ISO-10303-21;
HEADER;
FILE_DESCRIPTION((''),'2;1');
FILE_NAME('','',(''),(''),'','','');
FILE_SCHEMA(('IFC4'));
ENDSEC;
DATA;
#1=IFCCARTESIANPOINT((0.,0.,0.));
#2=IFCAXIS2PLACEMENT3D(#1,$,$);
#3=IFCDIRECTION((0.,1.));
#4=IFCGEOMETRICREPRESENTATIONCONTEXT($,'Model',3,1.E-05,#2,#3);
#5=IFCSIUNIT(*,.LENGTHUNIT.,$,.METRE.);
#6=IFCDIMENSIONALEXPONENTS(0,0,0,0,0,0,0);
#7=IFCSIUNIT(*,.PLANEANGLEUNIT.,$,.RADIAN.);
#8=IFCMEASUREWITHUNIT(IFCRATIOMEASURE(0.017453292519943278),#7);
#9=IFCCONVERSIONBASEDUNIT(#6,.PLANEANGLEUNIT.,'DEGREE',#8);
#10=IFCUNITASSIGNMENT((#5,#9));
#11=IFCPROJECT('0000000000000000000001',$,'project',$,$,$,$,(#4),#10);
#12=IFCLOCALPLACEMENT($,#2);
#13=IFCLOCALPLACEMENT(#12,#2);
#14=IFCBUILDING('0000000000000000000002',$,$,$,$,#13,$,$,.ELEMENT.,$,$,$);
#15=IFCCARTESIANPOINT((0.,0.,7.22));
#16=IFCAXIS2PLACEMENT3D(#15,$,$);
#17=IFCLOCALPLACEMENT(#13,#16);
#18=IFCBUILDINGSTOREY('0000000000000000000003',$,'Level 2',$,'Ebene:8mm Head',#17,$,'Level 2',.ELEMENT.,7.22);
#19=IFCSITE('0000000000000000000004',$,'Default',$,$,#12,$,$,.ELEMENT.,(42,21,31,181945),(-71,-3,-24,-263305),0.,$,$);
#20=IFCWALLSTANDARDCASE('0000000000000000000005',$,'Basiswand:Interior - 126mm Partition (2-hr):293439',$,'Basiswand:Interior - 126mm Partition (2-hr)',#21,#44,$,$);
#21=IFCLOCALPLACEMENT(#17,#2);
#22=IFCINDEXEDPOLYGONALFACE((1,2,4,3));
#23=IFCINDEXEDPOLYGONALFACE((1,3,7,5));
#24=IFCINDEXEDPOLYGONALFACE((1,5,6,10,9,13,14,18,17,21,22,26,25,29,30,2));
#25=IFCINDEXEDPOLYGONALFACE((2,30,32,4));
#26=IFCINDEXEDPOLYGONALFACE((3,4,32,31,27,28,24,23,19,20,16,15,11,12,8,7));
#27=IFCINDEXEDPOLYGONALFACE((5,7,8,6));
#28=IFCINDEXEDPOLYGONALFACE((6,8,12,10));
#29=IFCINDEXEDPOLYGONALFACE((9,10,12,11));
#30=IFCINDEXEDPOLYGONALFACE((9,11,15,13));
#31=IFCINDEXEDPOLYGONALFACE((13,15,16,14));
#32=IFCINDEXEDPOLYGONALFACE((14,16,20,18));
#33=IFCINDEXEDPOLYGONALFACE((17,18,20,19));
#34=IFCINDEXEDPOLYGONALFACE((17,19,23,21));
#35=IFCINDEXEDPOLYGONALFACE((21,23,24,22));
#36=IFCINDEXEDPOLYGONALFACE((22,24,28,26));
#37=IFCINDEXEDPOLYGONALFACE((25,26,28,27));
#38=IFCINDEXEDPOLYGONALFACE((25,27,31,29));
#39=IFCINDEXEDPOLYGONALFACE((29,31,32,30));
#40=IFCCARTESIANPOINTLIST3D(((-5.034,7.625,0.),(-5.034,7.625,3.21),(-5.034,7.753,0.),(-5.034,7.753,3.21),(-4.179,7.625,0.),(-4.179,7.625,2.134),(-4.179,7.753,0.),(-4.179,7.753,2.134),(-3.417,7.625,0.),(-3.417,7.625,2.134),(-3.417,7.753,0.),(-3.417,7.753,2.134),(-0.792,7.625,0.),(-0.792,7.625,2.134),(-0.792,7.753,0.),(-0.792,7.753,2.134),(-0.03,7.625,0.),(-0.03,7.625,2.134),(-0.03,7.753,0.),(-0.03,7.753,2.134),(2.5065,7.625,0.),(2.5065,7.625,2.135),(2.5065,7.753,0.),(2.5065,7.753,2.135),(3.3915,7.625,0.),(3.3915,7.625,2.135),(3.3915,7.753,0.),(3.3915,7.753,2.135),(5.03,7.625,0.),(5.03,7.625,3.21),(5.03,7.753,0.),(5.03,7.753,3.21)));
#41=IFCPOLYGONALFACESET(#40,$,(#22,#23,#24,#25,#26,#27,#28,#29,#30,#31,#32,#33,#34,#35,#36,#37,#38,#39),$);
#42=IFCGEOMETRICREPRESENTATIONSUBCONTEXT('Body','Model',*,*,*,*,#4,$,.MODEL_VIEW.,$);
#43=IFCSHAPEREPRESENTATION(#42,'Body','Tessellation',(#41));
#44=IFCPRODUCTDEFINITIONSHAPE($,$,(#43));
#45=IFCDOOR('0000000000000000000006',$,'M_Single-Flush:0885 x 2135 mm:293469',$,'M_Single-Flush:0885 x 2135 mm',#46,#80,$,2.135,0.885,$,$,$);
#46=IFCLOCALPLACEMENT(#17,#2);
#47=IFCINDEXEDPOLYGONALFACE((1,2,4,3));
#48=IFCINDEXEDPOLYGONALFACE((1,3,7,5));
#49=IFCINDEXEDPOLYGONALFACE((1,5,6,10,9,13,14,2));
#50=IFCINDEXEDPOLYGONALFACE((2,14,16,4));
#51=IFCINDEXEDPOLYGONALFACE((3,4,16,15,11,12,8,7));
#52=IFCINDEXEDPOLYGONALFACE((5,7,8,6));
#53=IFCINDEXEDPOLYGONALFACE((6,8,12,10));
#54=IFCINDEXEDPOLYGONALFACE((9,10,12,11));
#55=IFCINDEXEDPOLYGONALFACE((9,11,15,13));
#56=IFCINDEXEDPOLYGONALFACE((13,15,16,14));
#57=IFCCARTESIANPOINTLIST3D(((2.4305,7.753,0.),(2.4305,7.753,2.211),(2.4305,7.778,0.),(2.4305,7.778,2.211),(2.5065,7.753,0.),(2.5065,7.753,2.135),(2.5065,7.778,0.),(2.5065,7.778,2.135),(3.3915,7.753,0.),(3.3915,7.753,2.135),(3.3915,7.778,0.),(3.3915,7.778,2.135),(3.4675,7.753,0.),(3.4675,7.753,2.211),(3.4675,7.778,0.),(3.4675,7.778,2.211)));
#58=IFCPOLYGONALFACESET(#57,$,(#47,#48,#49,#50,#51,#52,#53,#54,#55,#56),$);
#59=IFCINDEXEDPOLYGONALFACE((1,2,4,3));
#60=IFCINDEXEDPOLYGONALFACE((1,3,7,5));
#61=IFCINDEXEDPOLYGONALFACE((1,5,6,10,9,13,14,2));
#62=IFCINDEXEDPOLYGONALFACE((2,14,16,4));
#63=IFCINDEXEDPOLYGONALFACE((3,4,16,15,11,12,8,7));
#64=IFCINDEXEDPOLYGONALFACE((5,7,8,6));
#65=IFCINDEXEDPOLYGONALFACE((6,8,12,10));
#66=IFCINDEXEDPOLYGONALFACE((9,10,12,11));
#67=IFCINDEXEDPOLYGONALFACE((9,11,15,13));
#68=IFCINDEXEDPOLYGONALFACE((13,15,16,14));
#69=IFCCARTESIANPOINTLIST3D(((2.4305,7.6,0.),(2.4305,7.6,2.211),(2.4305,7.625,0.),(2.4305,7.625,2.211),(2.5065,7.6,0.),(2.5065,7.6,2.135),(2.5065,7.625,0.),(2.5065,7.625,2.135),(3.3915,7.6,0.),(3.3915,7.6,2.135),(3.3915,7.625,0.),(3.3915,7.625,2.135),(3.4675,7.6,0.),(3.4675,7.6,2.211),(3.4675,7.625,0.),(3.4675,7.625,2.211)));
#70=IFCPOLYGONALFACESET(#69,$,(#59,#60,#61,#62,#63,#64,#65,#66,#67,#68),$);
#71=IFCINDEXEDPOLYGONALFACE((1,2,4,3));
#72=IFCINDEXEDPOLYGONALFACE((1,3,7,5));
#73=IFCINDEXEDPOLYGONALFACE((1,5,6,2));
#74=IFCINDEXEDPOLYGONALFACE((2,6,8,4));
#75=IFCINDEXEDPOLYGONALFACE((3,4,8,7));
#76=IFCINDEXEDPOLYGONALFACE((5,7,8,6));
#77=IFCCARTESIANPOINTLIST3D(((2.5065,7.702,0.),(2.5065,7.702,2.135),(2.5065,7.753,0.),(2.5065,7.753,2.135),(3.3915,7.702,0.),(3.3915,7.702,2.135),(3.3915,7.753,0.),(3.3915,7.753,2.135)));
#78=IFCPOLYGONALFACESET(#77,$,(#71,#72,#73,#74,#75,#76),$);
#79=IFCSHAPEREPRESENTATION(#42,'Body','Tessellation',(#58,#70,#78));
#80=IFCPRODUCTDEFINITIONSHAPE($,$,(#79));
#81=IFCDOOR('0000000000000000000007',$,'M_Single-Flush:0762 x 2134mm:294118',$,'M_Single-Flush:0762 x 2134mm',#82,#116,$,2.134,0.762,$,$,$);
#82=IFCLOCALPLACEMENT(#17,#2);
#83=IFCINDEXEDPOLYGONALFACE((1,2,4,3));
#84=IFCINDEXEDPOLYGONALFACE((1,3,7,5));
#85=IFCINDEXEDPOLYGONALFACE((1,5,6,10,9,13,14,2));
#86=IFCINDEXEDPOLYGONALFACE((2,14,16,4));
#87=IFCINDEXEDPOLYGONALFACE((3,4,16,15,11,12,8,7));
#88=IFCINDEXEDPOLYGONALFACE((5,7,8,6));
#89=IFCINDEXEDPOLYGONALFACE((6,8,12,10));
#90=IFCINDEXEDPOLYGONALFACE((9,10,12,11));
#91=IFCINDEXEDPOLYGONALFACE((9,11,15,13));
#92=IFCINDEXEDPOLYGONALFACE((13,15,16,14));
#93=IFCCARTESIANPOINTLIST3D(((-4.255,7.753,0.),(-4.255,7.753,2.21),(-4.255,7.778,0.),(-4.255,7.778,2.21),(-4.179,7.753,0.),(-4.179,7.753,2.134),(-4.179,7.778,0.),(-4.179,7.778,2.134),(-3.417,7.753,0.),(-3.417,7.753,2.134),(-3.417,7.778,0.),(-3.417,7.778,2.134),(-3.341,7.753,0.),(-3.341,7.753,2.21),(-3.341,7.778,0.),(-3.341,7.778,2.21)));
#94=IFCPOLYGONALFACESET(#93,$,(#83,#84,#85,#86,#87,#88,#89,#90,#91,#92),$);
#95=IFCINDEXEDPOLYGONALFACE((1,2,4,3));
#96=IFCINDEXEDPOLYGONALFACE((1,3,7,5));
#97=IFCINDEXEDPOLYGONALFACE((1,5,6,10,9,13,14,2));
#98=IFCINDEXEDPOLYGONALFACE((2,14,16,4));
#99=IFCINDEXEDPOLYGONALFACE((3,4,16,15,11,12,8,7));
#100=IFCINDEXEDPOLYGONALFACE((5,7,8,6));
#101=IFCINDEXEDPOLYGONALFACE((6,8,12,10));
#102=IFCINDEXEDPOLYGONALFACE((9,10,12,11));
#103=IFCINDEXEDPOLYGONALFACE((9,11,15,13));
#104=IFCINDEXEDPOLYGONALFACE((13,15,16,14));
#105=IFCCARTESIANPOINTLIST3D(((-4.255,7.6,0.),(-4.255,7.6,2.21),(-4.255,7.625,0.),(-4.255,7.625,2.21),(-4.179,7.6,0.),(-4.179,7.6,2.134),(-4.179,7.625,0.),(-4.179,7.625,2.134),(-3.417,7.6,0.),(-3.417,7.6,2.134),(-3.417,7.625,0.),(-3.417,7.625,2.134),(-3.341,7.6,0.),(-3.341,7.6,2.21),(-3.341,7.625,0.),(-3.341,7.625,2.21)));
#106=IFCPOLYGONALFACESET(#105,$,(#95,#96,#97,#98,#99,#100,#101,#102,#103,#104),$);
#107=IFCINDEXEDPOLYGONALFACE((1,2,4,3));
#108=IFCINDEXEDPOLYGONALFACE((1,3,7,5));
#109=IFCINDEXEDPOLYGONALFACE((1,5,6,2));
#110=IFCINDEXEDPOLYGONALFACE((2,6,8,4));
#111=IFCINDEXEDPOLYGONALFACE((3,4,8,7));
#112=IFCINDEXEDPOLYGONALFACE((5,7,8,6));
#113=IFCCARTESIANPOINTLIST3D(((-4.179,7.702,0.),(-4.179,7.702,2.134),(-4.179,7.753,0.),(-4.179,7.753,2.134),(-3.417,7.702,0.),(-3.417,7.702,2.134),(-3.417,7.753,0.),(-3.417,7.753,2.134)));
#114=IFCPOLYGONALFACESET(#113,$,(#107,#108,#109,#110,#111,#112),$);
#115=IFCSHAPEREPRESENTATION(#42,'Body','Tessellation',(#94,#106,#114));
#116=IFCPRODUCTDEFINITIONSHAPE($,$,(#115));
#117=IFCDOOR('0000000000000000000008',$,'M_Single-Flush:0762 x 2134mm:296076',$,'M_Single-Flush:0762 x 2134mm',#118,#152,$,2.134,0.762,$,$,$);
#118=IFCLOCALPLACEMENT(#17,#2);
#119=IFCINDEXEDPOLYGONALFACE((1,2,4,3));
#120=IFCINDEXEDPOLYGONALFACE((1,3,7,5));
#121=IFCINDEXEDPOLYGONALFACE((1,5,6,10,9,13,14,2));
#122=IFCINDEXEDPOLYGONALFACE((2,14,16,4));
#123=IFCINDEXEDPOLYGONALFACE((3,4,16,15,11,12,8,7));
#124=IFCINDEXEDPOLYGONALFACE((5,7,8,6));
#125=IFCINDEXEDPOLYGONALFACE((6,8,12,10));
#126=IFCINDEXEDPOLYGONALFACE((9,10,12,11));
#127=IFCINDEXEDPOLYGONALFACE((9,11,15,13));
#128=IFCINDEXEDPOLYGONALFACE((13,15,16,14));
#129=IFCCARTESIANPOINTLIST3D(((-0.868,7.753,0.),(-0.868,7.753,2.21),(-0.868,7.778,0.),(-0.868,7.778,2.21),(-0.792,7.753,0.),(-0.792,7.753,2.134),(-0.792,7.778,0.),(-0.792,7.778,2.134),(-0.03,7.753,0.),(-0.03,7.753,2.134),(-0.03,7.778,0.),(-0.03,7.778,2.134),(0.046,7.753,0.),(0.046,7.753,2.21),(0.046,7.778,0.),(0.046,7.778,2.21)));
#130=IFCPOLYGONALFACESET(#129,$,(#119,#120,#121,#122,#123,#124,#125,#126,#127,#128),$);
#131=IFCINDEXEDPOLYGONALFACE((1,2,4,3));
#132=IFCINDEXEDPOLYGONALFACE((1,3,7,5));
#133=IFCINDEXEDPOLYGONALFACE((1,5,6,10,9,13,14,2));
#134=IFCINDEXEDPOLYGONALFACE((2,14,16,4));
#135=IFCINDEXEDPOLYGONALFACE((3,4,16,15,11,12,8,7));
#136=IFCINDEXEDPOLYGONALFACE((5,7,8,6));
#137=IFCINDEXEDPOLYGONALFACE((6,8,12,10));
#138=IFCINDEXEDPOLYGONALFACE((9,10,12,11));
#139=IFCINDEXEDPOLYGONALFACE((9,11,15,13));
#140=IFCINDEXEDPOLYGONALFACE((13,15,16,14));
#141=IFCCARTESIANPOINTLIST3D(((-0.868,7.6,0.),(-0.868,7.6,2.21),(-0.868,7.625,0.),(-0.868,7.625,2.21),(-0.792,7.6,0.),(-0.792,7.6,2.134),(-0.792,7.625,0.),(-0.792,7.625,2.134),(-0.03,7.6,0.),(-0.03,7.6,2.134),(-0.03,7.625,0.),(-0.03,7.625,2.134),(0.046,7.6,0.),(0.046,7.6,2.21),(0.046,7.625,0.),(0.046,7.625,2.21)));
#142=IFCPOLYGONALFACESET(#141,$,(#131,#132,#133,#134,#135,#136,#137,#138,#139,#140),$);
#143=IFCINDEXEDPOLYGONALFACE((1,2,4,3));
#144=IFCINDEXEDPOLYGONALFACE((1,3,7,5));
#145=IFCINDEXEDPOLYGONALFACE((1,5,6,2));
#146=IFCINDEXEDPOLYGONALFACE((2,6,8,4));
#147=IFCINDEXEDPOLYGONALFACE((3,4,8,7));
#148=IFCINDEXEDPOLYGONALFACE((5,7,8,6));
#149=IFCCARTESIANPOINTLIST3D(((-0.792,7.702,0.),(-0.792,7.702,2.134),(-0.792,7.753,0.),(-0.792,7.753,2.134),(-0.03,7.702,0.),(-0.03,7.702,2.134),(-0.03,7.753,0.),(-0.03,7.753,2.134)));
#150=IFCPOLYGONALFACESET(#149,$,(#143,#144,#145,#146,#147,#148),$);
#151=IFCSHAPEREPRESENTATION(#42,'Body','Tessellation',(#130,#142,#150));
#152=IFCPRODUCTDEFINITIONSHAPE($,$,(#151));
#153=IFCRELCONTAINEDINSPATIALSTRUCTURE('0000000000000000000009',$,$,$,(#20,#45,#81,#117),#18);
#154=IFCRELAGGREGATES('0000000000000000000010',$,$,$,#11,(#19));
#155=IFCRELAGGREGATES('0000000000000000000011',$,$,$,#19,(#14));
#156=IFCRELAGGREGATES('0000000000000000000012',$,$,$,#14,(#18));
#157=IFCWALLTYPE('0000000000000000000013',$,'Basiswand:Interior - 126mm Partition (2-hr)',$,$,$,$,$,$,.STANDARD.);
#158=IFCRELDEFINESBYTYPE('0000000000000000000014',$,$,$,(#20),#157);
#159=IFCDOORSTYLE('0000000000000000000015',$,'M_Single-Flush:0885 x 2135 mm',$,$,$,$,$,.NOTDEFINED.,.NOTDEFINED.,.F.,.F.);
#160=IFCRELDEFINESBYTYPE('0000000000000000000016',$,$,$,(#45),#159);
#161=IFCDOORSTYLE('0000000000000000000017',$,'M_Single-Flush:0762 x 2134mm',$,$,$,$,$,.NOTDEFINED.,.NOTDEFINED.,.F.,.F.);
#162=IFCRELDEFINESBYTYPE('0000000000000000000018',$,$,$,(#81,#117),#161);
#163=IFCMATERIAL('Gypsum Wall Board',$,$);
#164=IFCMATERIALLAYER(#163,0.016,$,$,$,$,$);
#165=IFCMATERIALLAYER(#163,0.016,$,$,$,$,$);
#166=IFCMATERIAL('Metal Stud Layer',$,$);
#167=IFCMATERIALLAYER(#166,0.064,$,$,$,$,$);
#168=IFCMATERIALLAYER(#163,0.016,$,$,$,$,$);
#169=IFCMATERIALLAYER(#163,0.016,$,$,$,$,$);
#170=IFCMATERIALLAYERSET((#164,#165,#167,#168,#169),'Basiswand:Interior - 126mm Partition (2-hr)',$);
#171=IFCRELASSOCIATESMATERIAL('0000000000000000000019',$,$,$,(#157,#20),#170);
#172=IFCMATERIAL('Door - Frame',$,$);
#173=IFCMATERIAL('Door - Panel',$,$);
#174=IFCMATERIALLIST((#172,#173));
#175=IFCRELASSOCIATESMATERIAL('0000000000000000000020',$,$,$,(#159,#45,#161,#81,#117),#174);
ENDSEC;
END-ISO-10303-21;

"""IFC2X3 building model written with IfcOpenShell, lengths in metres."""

from ifc_helpers import new_model, entity, si_unit, converted_unit, direction, frame, frame_2d, origin, place, context, subcontext, project, spatial, polyline, rectangle, outline, extrude, clip, bounded_halfspace, source, transform, mapped, material, material_list, layer, layer_set, layer_usage, type_object, type_shapes, element, fill, save


model = new_model("IFC2X3")

# Units and contexts
model_context = context("Model", 3, precision=1e-05, world=origin(), true_north=direction((0.0, 1.0)))
body_context = subcontext(model_context, "Body", "Model", "MODEL_VIEW")
ifc_project = project(units=[si_unit("LENGTHUNIT", "METRE"), converted_unit("PLANEANGLEUNIT", "DEGREE", entity("IfcRatioMeasure", 0.017453292519943278), si_unit("PLANEANGLEUNIT", "RADIAN"), dimensions=[0, 0, 0, 0, 0, 0, 0])], contexts=[model_context])

# Site, building, storey
site_placement = place(None, origin())
site = spatial("IfcSite", under=ifc_project, at=site_placement, Name="Default", CompositionType="ELEMENT", RefLatitude=(42, 21, 31, 181945), RefLongitude=(-71, -3, -24, -263305), RefElevation=0.0)
building_placement = place(site_placement, origin())
building = spatial("IfcBuilding", under=site, at=building_placement, CompositionType="ELEMENT")
storey_placement = place(building_placement, frame((0.0, 0.0, 7.22)))
storey = spatial("IfcBuildingStorey", under=building, at=storey_placement, Name="Level 2", ObjectType="Ebene:8mm Head", LongName="Level 2", CompositionType="ELEMENT", Elevation=7.22)

# Shared definitions
ifc_material_1 = material(Name="Gypsum Wall Board")
ifc_layer_1 = layer(ifc_material_1, 0.016)
ifc_layer_2 = layer(ifc_material_1, 0.016)
ifc_material_2 = material(Name="Metal Stud Layer")
ifc_layer_3 = layer(ifc_material_2, 0.064)
ifc_layer_4 = layer(ifc_material_1, 0.016)
ifc_layer_5 = layer(ifc_material_1, 0.016)
ifc_layer_set = layer_set([ifc_layer_1, ifc_layer_2, ifc_layer_3, ifc_layer_4, ifc_layer_5], Name="Basiswand:Interior - 126mm Partition (2-hr)")
ifc_layer_usage = layer_usage(ifc_layer_set, "AXIS2", "POSITIVE", -0.064)
wall_type = type_object("IfcWallType", Name="Basiswand:Interior - 126mm Partition (2-hr)", PredefinedType="STANDARD", material=ifc_layer_set)
ifc_material_3 = material(Name="Door - Frame")
ifc_material_4 = material(Name="Door - Panel")
ifc_material_list = material_list([ifc_material_3, ifc_material_4])

# Wall, openings, doors
wall_1_placement = place(storey_placement, frame((-5.034, 7.689, 0.0)))
wall_1 = element("IfcWallStandardCase", 1, at=wall_1_placement, inside=storey, type_object=wall_type, material=ifc_layer_usage, Name="Basiswand:Interior - 126mm Partition (2-hr):293439", ObjectType="Basiswand:Interior - 126mm Partition (2-hr)", context=body_context, shape_type="Clipping", body=[
    clip(extrude(rectangle(XDim=10.064, YDim=0.128, at=frame_2d((5.032, 0.0), x_axis=(1.0, 0.0))), origin(), (0.0, 0.0, 1.0), 3.21), bounded_halfspace(frame((0.0, -0.064, 3.21), z_axis=(0.0, 0.0, -1.0), x_axis=(0.0, 1.0, 0.0)), True, frame((0.0, -0.064, 3.21)), polyline([(0.0, 0.0), (10.064, 0.0), (10.064, 0.128), (6.887, 0.128), (6.759, 0.128), (3.387, 0.128), (3.259, 0.128), (0.0, 0.128), (0.0, 0.0)]))),
])
opening_1_placement = place(wall_1_placement, frame((7.5405, -0.064, 0.0)))
opening_1 = element("IfcOpeningElement", 2, at=opening_1_placement, cuts=wall_1, ObjectType="Opening", context=body_context, shape_type="SweptSolid", body=[
    extrude(rectangle(XDim=0.885, YDim=2.135, at=frame_2d((1.0675, 0.4425), x_axis=(0.0, -1.0))), frame((0.0, 0.0, 0.0), z_axis=(0.0, 1.0, 0.0), x_axis=(0.0, 0.0, 1.0)), (0.0, 0.0, 1.0), 0.128),
])
opening_2_placement = place(wall_1_placement, frame((0.855, -0.064, 0.0)))
opening_2 = element("IfcOpeningElement", 3, at=opening_2_placement, cuts=wall_1, ObjectType="Opening", context=body_context, shape_type="SweptSolid", body=[
    extrude(rectangle(XDim=0.762, YDim=2.134, at=frame_2d((1.067, 0.381), x_axis=(0.0, -1.0))), frame((0.0, 0.0, 0.0), z_axis=(0.0, 1.0, 0.0), x_axis=(0.0, 0.0, 1.0)), (0.0, 0.0, 1.0), 0.128),
])
opening_3_placement = place(wall_1_placement, frame((4.242, -0.064, 0.0)))
opening_3 = element("IfcOpeningElement", 4, at=opening_3_placement, cuts=wall_1, ObjectType="Opening", context=body_context, shape_type="SweptSolid", body=[
    extrude(rectangle(XDim=0.762, YDim=2.134, at=frame_2d((1.067, 0.381), x_axis=(0.0, -1.0))), frame((0.0, 0.0, 0.0), z_axis=(0.0, 1.0, 0.0), x_axis=(0.0, 0.0, 1.0)), (0.0, 0.0, 1.0), 0.128),
])
door_style_1 = type_object("IfcDoorStyle", Name="M_Single-Flush:0885 x 2135 mm", ConstructionType="NOTDEFINED", OperationType="NOTDEFINED", ParameterTakesPrecedence=False, Sizeable=False, material=ifc_material_list)
shared_shape_1 = source(origin(), body_context, "Body", "SweptSolid", [
    extrude(outline(polyline([(-0.5185, -1.1245), (0.5185, -1.1245), (0.5185, 1.0865), (0.4425, 1.0865), (0.4425, -1.0485), (-0.4425, -1.0485), (-0.4425, 1.0865), (-0.5185, 1.0865), (-0.5185, -1.1245)])), frame((0.4425, 0.153, 1.0865), z_axis=(0.0, -1.0, 0.0), x_axis=(-1.0, 0.0, 0.0)), (0.0, 0.0, 1.0), 0.025),
    extrude(outline(polyline([(-1.1245, -0.5185), (1.0865, -0.5185), (1.0865, -0.4425), (-1.0485, -0.4425), (-1.0485, 0.4425), (1.0865, 0.4425), (1.0865, 0.5185), (-1.1245, 0.5185), (-1.1245, -0.5185)])), frame((0.4425, 0.0, 1.0865), z_axis=(0.0, -1.0, 0.0), x_axis=(0.0, 0.0, -1.0)), (0.0, 0.0, 1.0), 0.025),
    extrude(rectangle(XDim=0.885, YDim=0.051, at=frame_2d((0.0, 0.0), x_axis=(1.0, 0.0))), frame((0.4425, 0.1025, 0.0)), (0.0, 0.0, 1.0), 2.135),
])
type_shapes(door_style_1, [shared_shape_1])
door_1_placement = place(opening_1_placement, origin())
door_1 = element("IfcDoor", 5, at=door_1_placement, inside=storey, type_object=door_style_1, material=ifc_material_list, Name="M_Single-Flush:0885 x 2135 mm:293469", ObjectType="M_Single-Flush:0885 x 2135 mm", OverallHeight=2.135, OverallWidth=0.885, context=body_context, shape_type="MappedRepresentation", body=[
    mapped(shared_shape_1, transform((0.0, 0.0, 0.0), scale=1.0)),
])
fill(opening_1, door_1)
door_style_2 = type_object("IfcDoorStyle", Name="M_Single-Flush:0762 x 2134mm", ConstructionType="NOTDEFINED", OperationType="NOTDEFINED", ParameterTakesPrecedence=False, Sizeable=False, material=ifc_material_list)
shared_shape_2 = source(origin(), body_context, "Body", "SweptSolid", [
    extrude(outline(polyline([(-0.457, -1.124), (0.457, -1.124), (0.457, 1.086), (0.381, 1.086), (0.381, -1.048), (-0.381, -1.048), (-0.381, 1.086), (-0.457, 1.086), (-0.457, -1.124)])), frame((0.381, 0.153, 1.086), z_axis=(0.0, -1.0, 0.0), x_axis=(-1.0, 0.0, 0.0)), (0.0, 0.0, 1.0), 0.025),
    extrude(outline(polyline([(-1.124, -0.457), (1.086, -0.457), (1.086, -0.381), (-1.048, -0.381), (-1.048, 0.381), (1.086, 0.381), (1.086, 0.457), (-1.124, 0.457), (-1.124, -0.457)])), frame((0.381, 0.0, 1.086), z_axis=(0.0, -1.0, 0.0), x_axis=(0.0, 0.0, -1.0)), (0.0, 0.0, 1.0), 0.025),
    extrude(rectangle(XDim=0.762, YDim=0.051, at=frame_2d((0.0, 0.0), x_axis=(1.0, 0.0))), frame((0.381, 0.1025, 0.0)), (0.0, 0.0, 1.0), 2.134),
])
type_shapes(door_style_2, [shared_shape_2])
door_2_placement = place(opening_2_placement, origin())
door_2 = element("IfcDoor", 6, at=door_2_placement, inside=storey, type_object=door_style_2, material=ifc_material_list, Name="M_Single-Flush:0762 x 2134mm:294118", ObjectType="M_Single-Flush:0762 x 2134mm", OverallHeight=2.134, OverallWidth=0.762, context=body_context, shape_type="MappedRepresentation", body=[
    mapped(shared_shape_2, transform((0.0, 0.0, 0.0), scale=1.0)),
])
fill(opening_2, door_2)
door_3_placement = place(opening_3_placement, origin())
door_3 = element("IfcDoor", 7, at=door_3_placement, inside=storey, type_object=door_style_2, material=ifc_material_list, Name="M_Single-Flush:0762 x 2134mm:296076", ObjectType="M_Single-Flush:0762 x 2134mm", OverallHeight=2.134, OverallWidth=0.762, context=body_context, shape_type="MappedRepresentation", body=[
    mapped(shared_shape_2, transform((0.0, 0.0, 0.0), scale=1.0)),
])
fill(opening_3, door_3)

save(model, "model.ifc")
